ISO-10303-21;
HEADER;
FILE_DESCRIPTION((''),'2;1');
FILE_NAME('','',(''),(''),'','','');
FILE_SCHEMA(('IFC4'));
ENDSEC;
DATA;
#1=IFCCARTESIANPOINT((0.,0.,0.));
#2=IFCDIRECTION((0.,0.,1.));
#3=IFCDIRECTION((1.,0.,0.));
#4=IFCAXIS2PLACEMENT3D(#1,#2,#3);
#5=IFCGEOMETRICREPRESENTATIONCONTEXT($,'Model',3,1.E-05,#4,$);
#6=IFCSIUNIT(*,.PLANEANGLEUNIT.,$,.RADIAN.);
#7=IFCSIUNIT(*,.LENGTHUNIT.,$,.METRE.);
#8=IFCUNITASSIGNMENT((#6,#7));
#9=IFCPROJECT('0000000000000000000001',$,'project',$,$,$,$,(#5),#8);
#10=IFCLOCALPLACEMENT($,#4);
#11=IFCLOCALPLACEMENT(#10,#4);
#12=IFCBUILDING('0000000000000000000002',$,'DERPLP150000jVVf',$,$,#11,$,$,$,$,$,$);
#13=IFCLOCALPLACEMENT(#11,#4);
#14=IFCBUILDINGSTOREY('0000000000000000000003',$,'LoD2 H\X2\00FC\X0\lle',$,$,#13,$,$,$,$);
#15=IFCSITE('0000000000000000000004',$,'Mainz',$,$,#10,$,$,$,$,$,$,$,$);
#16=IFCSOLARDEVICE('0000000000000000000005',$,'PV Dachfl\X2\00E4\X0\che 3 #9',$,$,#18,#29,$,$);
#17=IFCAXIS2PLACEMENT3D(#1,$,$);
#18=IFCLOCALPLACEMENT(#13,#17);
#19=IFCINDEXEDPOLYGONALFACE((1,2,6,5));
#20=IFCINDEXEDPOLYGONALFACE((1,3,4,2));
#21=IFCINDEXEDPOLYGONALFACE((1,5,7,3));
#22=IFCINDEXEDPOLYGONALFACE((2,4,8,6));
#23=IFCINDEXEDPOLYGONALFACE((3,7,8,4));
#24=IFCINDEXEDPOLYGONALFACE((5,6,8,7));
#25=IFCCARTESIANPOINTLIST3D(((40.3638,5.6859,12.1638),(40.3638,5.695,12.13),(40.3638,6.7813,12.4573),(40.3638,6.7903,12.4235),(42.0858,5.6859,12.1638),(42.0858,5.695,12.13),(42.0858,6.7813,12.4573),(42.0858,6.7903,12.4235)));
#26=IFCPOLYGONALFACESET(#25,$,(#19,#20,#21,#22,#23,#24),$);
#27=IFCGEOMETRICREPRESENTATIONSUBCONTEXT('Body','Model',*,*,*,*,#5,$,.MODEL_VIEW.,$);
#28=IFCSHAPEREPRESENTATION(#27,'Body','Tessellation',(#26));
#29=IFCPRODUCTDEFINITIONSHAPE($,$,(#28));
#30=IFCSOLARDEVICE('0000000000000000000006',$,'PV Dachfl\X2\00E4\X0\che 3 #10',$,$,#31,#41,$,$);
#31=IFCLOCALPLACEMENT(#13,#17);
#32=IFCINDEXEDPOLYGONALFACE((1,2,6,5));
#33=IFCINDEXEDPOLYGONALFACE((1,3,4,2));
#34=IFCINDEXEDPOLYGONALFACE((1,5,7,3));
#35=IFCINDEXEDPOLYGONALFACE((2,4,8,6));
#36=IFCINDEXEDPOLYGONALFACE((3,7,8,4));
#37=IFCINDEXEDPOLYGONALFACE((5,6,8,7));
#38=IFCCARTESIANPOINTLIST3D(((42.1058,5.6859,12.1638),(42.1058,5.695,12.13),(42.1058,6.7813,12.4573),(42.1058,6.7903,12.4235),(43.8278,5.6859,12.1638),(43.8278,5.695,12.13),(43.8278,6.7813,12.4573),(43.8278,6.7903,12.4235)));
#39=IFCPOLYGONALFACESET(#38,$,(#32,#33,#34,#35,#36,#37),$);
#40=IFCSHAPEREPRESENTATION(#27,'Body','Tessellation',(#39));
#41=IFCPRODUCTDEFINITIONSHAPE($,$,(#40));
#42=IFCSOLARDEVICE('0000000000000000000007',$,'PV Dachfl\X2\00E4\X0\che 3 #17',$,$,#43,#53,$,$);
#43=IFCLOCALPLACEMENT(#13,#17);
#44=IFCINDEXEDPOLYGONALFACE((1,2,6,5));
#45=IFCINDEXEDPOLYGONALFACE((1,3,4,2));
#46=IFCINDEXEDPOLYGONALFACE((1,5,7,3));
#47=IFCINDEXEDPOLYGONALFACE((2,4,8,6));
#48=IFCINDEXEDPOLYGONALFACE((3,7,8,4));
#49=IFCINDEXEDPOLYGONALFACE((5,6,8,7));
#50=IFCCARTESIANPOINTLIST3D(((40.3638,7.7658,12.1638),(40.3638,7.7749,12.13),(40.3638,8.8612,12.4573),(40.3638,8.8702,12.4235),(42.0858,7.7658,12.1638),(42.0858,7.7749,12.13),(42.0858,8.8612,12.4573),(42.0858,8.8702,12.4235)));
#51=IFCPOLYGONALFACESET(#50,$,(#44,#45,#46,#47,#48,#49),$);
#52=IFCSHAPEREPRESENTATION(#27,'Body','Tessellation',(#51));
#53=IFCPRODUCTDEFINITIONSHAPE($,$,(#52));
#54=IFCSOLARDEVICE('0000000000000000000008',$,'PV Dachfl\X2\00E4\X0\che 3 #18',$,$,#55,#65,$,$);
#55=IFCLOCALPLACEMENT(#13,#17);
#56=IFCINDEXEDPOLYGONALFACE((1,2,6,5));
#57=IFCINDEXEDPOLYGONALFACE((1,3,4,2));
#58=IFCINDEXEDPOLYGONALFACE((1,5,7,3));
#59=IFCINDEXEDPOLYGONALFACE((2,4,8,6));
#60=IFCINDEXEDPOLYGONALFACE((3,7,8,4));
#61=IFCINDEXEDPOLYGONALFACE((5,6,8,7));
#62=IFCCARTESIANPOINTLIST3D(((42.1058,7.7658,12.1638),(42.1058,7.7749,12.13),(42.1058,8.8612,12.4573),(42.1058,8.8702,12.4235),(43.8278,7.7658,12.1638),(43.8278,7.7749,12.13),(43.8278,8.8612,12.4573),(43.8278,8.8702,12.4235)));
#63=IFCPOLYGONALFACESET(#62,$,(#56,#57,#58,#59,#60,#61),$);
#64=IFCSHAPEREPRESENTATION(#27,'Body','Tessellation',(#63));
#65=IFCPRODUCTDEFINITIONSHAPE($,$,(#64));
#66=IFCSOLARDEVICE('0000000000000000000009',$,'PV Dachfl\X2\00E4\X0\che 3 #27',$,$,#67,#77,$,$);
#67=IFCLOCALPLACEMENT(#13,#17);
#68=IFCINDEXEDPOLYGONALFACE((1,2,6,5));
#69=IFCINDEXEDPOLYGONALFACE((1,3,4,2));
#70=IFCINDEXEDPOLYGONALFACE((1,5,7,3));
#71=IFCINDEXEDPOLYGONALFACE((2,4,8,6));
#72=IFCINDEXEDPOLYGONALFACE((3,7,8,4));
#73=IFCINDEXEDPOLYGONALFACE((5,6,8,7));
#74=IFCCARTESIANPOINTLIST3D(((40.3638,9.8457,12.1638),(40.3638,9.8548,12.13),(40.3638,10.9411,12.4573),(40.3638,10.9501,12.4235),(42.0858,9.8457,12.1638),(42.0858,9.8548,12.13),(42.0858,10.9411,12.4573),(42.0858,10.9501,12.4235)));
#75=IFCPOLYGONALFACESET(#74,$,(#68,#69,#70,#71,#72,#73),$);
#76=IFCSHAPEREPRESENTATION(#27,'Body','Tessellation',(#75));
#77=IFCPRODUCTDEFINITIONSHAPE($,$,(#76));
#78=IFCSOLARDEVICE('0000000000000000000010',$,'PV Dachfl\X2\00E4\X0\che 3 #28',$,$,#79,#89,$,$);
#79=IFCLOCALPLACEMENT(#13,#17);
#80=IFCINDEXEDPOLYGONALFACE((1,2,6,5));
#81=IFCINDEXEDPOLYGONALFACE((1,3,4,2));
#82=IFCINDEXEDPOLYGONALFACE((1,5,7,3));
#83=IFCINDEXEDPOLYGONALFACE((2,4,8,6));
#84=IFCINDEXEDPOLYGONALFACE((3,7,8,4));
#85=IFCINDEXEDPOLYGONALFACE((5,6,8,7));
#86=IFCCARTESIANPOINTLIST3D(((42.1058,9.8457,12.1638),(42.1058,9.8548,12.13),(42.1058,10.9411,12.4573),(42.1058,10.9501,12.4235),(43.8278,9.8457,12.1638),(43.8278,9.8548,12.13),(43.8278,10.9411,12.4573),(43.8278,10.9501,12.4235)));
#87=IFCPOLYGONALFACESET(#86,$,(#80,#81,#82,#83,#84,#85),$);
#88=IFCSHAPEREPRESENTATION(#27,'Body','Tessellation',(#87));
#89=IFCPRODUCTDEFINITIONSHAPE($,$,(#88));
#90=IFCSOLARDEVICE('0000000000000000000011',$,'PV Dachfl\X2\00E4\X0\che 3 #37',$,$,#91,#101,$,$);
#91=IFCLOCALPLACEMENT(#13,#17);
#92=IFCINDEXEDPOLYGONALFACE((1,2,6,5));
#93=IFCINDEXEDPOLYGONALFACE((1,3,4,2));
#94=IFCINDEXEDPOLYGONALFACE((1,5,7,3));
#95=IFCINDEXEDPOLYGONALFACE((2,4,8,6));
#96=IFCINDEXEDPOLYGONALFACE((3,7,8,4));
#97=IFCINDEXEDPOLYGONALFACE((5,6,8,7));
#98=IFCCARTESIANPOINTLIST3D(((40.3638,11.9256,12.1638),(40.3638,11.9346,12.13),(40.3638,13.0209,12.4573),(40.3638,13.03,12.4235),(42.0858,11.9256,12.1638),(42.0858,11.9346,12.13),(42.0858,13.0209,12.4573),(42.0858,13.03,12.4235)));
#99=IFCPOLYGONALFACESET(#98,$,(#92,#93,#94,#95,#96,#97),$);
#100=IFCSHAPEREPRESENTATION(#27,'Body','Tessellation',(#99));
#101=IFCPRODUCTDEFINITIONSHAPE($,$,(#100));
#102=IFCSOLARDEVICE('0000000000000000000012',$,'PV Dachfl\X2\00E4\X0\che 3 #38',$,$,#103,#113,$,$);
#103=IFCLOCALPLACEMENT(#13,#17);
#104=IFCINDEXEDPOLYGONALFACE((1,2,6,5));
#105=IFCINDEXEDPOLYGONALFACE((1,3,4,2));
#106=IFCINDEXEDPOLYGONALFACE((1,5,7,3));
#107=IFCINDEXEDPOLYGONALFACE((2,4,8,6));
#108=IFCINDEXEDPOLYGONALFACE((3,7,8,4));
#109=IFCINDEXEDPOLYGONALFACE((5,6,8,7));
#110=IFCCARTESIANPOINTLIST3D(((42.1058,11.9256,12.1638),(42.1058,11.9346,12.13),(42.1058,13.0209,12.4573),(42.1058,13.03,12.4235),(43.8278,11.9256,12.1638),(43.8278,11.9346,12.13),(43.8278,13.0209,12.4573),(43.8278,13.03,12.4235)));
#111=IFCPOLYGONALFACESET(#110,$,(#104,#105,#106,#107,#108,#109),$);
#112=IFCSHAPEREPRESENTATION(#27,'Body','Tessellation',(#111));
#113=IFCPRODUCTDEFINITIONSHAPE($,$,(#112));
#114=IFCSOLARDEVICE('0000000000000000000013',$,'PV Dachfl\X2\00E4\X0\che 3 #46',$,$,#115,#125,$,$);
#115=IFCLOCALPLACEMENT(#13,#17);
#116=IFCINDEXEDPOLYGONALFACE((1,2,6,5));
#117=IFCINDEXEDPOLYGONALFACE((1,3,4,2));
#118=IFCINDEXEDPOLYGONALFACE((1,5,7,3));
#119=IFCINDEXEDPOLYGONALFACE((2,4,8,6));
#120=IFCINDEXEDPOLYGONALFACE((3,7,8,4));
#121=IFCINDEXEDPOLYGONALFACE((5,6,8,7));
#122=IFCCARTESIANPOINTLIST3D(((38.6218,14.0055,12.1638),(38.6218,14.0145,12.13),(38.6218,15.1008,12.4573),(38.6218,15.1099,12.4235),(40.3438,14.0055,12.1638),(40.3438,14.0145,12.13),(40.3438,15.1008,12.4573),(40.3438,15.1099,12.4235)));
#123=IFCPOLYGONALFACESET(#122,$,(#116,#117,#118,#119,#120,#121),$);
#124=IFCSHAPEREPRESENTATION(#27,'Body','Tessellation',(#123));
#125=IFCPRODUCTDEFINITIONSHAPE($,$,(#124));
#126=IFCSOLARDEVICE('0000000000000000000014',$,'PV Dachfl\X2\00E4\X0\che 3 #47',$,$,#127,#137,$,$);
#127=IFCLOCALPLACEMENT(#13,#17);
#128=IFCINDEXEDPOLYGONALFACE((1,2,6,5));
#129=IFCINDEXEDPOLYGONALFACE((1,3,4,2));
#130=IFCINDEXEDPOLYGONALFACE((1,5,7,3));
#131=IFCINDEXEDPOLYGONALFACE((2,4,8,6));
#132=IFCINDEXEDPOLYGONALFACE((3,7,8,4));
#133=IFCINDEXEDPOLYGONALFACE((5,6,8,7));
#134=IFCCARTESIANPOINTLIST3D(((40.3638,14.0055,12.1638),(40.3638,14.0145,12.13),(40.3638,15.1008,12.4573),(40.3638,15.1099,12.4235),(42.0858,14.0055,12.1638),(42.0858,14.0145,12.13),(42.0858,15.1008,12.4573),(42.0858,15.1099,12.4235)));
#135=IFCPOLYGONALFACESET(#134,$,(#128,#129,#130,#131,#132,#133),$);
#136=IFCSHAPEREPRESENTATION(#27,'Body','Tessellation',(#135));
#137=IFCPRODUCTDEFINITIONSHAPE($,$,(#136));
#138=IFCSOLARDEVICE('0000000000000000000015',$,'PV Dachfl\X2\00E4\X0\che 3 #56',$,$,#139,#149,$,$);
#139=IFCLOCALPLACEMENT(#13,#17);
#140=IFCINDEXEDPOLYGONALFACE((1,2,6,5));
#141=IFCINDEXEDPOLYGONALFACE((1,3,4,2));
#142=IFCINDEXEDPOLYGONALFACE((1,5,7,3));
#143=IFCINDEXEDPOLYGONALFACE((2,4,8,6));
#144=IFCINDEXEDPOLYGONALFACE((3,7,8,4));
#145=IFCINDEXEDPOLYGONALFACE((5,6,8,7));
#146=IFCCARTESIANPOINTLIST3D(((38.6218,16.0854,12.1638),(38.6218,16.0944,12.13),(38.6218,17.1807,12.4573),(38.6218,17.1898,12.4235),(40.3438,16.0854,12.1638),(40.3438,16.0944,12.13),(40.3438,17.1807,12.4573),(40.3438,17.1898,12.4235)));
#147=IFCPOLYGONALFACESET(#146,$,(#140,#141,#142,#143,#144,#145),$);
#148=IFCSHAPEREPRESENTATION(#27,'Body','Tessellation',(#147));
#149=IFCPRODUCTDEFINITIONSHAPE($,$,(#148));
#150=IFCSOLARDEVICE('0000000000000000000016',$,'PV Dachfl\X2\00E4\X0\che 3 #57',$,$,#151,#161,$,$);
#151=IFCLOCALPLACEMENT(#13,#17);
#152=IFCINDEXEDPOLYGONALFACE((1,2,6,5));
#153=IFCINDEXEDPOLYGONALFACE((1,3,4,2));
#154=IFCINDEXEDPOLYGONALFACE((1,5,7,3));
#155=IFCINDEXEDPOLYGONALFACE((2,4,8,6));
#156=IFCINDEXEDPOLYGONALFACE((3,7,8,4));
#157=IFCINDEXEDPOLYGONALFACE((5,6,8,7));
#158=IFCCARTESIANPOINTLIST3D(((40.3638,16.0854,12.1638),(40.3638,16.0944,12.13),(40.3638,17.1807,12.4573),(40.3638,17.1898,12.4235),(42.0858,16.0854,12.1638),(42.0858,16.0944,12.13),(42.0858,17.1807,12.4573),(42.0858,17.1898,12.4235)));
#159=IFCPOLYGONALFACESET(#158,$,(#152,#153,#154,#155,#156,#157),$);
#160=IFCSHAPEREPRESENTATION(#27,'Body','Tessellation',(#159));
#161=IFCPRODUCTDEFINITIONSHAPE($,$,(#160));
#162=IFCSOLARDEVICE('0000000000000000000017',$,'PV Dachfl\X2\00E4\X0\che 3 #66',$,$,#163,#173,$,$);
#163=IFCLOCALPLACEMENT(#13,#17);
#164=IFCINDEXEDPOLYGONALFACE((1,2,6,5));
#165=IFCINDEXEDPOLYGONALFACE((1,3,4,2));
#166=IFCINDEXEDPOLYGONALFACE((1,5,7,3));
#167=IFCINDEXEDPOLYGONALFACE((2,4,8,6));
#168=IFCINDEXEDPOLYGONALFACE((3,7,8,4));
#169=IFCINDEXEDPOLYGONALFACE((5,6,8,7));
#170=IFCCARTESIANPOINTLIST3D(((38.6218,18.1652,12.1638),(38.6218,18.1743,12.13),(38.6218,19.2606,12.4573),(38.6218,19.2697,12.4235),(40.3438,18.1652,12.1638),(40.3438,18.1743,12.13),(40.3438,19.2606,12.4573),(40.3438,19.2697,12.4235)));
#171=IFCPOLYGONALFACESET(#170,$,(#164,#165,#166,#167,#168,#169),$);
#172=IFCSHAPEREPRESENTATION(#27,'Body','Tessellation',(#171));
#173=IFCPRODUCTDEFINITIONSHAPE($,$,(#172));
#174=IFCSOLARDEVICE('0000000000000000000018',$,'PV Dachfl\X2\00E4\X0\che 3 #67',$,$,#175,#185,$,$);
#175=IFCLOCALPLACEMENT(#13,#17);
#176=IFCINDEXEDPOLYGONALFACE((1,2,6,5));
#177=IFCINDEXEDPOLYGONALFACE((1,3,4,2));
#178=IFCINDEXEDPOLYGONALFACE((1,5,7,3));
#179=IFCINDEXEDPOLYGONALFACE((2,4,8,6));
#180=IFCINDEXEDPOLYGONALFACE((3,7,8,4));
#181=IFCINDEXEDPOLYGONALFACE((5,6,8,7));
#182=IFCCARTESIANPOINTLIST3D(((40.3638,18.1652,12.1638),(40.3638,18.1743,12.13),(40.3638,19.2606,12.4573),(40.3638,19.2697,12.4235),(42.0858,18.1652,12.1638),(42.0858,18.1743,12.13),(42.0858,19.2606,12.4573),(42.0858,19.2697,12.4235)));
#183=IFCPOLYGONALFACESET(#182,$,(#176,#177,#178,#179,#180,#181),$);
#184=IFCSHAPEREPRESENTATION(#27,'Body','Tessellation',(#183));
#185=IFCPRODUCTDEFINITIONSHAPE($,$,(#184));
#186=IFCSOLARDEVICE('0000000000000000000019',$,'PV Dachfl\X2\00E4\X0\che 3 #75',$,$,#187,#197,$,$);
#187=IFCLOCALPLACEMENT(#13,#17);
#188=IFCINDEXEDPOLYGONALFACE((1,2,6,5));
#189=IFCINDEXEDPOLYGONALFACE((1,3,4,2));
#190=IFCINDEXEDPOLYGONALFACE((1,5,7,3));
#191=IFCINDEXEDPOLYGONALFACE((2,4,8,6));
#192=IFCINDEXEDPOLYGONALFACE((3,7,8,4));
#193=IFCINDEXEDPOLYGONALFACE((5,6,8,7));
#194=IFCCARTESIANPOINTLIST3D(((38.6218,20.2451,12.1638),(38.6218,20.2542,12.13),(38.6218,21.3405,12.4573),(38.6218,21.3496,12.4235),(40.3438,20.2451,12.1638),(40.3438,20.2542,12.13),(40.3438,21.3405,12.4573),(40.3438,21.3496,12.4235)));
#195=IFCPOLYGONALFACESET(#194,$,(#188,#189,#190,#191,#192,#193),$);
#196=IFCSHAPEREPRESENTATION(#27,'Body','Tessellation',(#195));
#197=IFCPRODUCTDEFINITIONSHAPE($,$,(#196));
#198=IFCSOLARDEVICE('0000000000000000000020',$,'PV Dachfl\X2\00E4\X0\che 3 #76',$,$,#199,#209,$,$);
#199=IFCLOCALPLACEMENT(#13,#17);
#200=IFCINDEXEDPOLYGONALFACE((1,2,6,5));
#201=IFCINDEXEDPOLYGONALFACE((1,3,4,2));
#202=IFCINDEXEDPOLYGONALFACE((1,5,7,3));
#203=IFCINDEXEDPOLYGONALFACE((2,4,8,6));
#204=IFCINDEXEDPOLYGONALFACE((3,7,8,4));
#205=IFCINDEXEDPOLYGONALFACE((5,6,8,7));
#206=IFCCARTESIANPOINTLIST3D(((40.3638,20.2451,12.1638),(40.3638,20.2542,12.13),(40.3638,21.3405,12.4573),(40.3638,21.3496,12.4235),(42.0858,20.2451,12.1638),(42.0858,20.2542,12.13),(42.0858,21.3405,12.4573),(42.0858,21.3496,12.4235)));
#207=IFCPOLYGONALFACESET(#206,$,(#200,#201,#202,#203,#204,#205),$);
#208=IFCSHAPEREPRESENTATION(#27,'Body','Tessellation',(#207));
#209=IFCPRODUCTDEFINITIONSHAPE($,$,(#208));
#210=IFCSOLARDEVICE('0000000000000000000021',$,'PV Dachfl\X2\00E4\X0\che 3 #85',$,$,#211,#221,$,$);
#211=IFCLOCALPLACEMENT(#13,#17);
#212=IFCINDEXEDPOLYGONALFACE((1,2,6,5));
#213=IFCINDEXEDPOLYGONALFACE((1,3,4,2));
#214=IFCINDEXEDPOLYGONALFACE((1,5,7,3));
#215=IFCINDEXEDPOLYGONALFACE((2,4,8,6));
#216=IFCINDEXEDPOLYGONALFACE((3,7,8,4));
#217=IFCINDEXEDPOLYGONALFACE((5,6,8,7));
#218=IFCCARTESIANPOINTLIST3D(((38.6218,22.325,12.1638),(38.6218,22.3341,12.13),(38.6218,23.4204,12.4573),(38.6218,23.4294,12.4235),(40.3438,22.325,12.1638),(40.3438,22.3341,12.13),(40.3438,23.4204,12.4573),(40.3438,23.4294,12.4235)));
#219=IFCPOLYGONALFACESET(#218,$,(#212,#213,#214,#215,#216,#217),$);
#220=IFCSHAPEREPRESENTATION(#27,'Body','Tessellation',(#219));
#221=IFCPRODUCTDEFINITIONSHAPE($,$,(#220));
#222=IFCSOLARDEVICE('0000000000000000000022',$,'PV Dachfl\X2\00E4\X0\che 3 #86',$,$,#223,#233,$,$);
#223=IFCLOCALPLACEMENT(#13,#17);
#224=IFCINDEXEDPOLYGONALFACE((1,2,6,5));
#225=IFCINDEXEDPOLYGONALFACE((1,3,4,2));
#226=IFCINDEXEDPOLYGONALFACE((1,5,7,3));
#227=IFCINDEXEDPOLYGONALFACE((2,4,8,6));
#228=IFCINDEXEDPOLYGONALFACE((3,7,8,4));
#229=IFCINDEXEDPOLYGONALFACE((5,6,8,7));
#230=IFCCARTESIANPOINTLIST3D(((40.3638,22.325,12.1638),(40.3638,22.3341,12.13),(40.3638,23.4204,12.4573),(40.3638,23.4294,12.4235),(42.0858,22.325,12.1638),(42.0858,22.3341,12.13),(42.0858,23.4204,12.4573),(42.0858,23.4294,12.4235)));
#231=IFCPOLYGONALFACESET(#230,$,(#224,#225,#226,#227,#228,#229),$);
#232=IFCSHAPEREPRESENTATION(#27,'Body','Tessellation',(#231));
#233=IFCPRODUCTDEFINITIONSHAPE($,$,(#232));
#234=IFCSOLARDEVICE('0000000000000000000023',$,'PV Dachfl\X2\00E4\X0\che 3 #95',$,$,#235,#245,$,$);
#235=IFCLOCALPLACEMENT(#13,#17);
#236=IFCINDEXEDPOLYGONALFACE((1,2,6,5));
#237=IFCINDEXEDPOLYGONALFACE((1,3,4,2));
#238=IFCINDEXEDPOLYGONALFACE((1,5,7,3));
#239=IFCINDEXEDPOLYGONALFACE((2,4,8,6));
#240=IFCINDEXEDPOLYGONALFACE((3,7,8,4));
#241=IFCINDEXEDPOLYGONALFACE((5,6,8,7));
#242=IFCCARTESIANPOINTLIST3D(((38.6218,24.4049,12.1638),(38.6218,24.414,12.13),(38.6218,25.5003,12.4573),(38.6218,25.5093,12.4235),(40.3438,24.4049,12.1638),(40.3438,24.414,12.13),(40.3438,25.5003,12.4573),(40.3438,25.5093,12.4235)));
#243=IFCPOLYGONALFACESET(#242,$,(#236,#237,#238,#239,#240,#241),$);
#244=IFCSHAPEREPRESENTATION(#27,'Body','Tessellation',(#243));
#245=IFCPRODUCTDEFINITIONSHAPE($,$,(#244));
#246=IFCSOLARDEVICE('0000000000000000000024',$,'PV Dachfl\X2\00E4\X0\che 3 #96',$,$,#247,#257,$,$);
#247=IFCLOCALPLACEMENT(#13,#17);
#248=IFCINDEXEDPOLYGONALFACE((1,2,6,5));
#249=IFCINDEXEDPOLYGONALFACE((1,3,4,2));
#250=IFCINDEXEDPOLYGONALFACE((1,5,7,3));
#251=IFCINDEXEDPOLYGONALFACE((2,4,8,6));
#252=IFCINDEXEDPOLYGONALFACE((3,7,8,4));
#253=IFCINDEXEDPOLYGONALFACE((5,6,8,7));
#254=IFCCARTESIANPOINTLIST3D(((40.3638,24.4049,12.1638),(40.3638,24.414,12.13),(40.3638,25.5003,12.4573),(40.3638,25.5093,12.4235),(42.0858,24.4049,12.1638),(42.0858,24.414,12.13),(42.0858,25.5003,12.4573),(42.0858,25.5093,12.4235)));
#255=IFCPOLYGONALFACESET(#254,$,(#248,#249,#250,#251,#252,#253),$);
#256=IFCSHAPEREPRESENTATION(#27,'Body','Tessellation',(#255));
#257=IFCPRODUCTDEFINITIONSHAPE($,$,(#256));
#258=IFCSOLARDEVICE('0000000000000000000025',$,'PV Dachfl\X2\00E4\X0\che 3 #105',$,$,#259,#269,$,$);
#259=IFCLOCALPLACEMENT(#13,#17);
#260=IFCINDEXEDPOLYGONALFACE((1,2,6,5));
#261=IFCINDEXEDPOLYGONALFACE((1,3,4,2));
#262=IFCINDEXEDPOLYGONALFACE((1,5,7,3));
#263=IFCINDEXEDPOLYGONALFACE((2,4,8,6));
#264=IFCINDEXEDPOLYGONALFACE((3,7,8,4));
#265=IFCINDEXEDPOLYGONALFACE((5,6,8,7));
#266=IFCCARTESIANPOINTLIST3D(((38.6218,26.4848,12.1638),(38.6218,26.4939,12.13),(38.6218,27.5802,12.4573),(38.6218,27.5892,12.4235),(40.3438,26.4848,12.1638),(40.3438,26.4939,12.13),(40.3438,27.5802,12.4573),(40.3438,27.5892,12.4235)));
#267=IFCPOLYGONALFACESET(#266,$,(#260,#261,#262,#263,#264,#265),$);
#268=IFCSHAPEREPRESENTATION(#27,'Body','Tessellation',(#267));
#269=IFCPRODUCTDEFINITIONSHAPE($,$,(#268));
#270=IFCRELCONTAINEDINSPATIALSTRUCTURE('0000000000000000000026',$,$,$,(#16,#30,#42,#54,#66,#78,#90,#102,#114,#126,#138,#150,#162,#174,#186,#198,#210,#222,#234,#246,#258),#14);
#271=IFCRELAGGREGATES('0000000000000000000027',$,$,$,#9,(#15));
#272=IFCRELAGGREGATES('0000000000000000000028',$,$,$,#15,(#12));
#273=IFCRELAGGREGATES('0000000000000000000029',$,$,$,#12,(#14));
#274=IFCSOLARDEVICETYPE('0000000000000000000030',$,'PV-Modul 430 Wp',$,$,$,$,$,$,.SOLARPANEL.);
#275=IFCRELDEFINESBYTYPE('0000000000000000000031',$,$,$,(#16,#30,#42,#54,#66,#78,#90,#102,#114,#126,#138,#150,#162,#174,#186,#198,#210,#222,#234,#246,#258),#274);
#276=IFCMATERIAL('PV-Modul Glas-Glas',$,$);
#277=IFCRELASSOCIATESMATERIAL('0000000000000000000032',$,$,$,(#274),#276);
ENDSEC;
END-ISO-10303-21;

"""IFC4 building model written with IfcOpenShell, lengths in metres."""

from ifc_helpers import new_model, si_unit, frame, frame_2d, origin, origin_with_axes, place, context, subcontext, project, spatial, rectangle, extrude, source, transform, mapped, material, type_object, type_shapes, element, save


model = new_model("IFC4")

# Units and contexts
model_context = context("Model", 3, precision=1e-05, world=origin_with_axes())
body_context = subcontext(model_context, "Body", "Model", "MODEL_VIEW")
ifc_project = project(units=[si_unit("PLANEANGLEUNIT", "RADIAN"), si_unit("LENGTHUNIT", "METRE")], contexts=[model_context])

# Site, building, storey
site_placement = place(None, origin_with_axes())
site = spatial("IfcSite", under=ifc_project, at=site_placement, Name="Mainz")
building_placement = place(site_placement, origin_with_axes())
building = spatial("IfcBuilding", under=site, at=building_placement, Name="DERPLP150000jVVf")
storey_placement = place(building_placement, origin_with_axes())
storey = spatial("IfcBuildingStorey", under=building, at=storey_placement, Name="LoD2 Hülle")

# Solar devices
ifc_material = material(Name="PV-Modul Glas-Glas")
solar_device_type = type_object("IfcSolarDeviceType", Name="PV-Modul 430 Wp", PredefinedType="SOLARPANEL", material=ifc_material)
shared_shape = source(origin_with_axes(), body_context, "Body", "SweptSolid", [
    extrude(rectangle(XDim=1.722, YDim=1.134, at=frame_2d((0.861, 0.567))), origin(), (0.0, 0.0, 1.0), 0.035),
])
type_shapes(solar_device_type, [shared_shape])
for number, where, z_axis, x_axis, name in (
    (1, (40.3638, 5.695, 12.13), (0.0, -0.258819, 0.965926), (1.0, 0.0, 0.0), "PV Dachfläche 3 #9"),
    (2, (42.1058, 5.695, 12.13), (0.0, -0.258819, 0.965926), (1.0, 0.0, 0.0), "PV Dachfläche 3 #10"),
    (3, (40.3638, 7.7749, 12.13), (0.0, -0.258819, 0.965926), (1.0, 0.0, 0.0), "PV Dachfläche 3 #17"),
    (4, (42.1058, 7.7749, 12.13), (0.0, -0.258819, 0.965926), (1.0, 0.0, 0.0), "PV Dachfläche 3 #18"),
    (5, (40.3638, 9.8548, 12.13), (0.0, -0.258819, 0.965926), (1.0, 0.0, 0.0), "PV Dachfläche 3 #27"),
    (6, (42.1058, 9.8548, 12.13), (0.0, -0.258819, 0.965926), (1.0, 0.0, 0.0), "PV Dachfläche 3 #28"),
    (7, (40.3638, 11.9346, 12.13), (0.0, -0.258819, 0.965926), (1.0, 0.0, 0.0), "PV Dachfläche 3 #37"),
    (8, (42.1058, 11.9346, 12.13), (0.0, -0.258819, 0.965926), (1.0, 0.0, 0.0), "PV Dachfläche 3 #38"),
    (9, (38.6218, 14.0145, 12.13), (0.0, -0.258819, 0.965926), (1.0, 0.0, 0.0), "PV Dachfläche 3 #46"),
    (10, (40.3638, 14.0145, 12.13), (0.0, -0.258819, 0.965926), (1.0, 0.0, 0.0), "PV Dachfläche 3 #47"),
    (11, (38.6218, 16.0944, 12.13), (0.0, -0.258819, 0.965926), (1.0, 0.0, 0.0), "PV Dachfläche 3 #56"),
    (12, (40.3638, 16.0944, 12.13), (0.0, -0.258819, 0.965926), (1.0, 0.0, 0.0), "PV Dachfläche 3 #57"),
    (13, (38.6218, 18.1743, 12.13), (0.0, -0.258819, 0.965926), (1.0, 0.0, 0.0), "PV Dachfläche 3 #66"),
    (14, (40.3638, 18.1743, 12.13), (0.0, -0.258819, 0.965926), (1.0, 0.0, 0.0), "PV Dachfläche 3 #67"),
    (15, (38.6218, 20.2542, 12.13), (0.0, -0.258819, 0.965926), (1.0, 0.0, 0.0), "PV Dachfläche 3 #75"),
    (16, (40.3638, 20.2542, 12.13), (0.0, -0.258819, 0.965926), (1.0, 0.0, 0.0), "PV Dachfläche 3 #76"),
    (17, (38.6218, 22.3341, 12.13), (0.0, -0.258819, 0.965926), (1.0, 0.0, 0.0), "PV Dachfläche 3 #85"),
    (18, (40.3638, 22.3341, 12.13), (0.0, -0.258819, 0.965926), (1.0, 0.0, 0.0), "PV Dachfläche 3 #86"),
    (19, (38.6218, 24.414, 12.13), (0.0, -0.258819, 0.965926), (1.0, 0.0, 0.0), "PV Dachfläche 3 #95"),
    (20, (40.3638, 24.414, 12.13), (0.0, -0.258819, 0.965926), (1.0, 0.0, 0.0), "PV Dachfläche 3 #96"),
    (21, (38.6218, 26.4939, 12.13), (0.0, -0.258819, 0.965926), (1.0, 0.0, 0.0), "PV Dachfläche 3 #105"),
):
    element("IfcSolarDevice", number, at=place(storey_placement, frame(where, z_axis=z_axis, x_axis=x_axis)), inside=storey, type_object=solar_device_type, Name=name, context=body_context, shape_type="MappedRepresentation", body=[
        mapped(shared_shape, transform((0.0, 0.0, 0.0), x_axis=(1.0, 0.0, 0.0), y_axis=(0.0, 1.0, 0.0), z_axis=(0.0, 0.0, 1.0), scale=1.0)),
    ])

save(model, "model.ifc")
